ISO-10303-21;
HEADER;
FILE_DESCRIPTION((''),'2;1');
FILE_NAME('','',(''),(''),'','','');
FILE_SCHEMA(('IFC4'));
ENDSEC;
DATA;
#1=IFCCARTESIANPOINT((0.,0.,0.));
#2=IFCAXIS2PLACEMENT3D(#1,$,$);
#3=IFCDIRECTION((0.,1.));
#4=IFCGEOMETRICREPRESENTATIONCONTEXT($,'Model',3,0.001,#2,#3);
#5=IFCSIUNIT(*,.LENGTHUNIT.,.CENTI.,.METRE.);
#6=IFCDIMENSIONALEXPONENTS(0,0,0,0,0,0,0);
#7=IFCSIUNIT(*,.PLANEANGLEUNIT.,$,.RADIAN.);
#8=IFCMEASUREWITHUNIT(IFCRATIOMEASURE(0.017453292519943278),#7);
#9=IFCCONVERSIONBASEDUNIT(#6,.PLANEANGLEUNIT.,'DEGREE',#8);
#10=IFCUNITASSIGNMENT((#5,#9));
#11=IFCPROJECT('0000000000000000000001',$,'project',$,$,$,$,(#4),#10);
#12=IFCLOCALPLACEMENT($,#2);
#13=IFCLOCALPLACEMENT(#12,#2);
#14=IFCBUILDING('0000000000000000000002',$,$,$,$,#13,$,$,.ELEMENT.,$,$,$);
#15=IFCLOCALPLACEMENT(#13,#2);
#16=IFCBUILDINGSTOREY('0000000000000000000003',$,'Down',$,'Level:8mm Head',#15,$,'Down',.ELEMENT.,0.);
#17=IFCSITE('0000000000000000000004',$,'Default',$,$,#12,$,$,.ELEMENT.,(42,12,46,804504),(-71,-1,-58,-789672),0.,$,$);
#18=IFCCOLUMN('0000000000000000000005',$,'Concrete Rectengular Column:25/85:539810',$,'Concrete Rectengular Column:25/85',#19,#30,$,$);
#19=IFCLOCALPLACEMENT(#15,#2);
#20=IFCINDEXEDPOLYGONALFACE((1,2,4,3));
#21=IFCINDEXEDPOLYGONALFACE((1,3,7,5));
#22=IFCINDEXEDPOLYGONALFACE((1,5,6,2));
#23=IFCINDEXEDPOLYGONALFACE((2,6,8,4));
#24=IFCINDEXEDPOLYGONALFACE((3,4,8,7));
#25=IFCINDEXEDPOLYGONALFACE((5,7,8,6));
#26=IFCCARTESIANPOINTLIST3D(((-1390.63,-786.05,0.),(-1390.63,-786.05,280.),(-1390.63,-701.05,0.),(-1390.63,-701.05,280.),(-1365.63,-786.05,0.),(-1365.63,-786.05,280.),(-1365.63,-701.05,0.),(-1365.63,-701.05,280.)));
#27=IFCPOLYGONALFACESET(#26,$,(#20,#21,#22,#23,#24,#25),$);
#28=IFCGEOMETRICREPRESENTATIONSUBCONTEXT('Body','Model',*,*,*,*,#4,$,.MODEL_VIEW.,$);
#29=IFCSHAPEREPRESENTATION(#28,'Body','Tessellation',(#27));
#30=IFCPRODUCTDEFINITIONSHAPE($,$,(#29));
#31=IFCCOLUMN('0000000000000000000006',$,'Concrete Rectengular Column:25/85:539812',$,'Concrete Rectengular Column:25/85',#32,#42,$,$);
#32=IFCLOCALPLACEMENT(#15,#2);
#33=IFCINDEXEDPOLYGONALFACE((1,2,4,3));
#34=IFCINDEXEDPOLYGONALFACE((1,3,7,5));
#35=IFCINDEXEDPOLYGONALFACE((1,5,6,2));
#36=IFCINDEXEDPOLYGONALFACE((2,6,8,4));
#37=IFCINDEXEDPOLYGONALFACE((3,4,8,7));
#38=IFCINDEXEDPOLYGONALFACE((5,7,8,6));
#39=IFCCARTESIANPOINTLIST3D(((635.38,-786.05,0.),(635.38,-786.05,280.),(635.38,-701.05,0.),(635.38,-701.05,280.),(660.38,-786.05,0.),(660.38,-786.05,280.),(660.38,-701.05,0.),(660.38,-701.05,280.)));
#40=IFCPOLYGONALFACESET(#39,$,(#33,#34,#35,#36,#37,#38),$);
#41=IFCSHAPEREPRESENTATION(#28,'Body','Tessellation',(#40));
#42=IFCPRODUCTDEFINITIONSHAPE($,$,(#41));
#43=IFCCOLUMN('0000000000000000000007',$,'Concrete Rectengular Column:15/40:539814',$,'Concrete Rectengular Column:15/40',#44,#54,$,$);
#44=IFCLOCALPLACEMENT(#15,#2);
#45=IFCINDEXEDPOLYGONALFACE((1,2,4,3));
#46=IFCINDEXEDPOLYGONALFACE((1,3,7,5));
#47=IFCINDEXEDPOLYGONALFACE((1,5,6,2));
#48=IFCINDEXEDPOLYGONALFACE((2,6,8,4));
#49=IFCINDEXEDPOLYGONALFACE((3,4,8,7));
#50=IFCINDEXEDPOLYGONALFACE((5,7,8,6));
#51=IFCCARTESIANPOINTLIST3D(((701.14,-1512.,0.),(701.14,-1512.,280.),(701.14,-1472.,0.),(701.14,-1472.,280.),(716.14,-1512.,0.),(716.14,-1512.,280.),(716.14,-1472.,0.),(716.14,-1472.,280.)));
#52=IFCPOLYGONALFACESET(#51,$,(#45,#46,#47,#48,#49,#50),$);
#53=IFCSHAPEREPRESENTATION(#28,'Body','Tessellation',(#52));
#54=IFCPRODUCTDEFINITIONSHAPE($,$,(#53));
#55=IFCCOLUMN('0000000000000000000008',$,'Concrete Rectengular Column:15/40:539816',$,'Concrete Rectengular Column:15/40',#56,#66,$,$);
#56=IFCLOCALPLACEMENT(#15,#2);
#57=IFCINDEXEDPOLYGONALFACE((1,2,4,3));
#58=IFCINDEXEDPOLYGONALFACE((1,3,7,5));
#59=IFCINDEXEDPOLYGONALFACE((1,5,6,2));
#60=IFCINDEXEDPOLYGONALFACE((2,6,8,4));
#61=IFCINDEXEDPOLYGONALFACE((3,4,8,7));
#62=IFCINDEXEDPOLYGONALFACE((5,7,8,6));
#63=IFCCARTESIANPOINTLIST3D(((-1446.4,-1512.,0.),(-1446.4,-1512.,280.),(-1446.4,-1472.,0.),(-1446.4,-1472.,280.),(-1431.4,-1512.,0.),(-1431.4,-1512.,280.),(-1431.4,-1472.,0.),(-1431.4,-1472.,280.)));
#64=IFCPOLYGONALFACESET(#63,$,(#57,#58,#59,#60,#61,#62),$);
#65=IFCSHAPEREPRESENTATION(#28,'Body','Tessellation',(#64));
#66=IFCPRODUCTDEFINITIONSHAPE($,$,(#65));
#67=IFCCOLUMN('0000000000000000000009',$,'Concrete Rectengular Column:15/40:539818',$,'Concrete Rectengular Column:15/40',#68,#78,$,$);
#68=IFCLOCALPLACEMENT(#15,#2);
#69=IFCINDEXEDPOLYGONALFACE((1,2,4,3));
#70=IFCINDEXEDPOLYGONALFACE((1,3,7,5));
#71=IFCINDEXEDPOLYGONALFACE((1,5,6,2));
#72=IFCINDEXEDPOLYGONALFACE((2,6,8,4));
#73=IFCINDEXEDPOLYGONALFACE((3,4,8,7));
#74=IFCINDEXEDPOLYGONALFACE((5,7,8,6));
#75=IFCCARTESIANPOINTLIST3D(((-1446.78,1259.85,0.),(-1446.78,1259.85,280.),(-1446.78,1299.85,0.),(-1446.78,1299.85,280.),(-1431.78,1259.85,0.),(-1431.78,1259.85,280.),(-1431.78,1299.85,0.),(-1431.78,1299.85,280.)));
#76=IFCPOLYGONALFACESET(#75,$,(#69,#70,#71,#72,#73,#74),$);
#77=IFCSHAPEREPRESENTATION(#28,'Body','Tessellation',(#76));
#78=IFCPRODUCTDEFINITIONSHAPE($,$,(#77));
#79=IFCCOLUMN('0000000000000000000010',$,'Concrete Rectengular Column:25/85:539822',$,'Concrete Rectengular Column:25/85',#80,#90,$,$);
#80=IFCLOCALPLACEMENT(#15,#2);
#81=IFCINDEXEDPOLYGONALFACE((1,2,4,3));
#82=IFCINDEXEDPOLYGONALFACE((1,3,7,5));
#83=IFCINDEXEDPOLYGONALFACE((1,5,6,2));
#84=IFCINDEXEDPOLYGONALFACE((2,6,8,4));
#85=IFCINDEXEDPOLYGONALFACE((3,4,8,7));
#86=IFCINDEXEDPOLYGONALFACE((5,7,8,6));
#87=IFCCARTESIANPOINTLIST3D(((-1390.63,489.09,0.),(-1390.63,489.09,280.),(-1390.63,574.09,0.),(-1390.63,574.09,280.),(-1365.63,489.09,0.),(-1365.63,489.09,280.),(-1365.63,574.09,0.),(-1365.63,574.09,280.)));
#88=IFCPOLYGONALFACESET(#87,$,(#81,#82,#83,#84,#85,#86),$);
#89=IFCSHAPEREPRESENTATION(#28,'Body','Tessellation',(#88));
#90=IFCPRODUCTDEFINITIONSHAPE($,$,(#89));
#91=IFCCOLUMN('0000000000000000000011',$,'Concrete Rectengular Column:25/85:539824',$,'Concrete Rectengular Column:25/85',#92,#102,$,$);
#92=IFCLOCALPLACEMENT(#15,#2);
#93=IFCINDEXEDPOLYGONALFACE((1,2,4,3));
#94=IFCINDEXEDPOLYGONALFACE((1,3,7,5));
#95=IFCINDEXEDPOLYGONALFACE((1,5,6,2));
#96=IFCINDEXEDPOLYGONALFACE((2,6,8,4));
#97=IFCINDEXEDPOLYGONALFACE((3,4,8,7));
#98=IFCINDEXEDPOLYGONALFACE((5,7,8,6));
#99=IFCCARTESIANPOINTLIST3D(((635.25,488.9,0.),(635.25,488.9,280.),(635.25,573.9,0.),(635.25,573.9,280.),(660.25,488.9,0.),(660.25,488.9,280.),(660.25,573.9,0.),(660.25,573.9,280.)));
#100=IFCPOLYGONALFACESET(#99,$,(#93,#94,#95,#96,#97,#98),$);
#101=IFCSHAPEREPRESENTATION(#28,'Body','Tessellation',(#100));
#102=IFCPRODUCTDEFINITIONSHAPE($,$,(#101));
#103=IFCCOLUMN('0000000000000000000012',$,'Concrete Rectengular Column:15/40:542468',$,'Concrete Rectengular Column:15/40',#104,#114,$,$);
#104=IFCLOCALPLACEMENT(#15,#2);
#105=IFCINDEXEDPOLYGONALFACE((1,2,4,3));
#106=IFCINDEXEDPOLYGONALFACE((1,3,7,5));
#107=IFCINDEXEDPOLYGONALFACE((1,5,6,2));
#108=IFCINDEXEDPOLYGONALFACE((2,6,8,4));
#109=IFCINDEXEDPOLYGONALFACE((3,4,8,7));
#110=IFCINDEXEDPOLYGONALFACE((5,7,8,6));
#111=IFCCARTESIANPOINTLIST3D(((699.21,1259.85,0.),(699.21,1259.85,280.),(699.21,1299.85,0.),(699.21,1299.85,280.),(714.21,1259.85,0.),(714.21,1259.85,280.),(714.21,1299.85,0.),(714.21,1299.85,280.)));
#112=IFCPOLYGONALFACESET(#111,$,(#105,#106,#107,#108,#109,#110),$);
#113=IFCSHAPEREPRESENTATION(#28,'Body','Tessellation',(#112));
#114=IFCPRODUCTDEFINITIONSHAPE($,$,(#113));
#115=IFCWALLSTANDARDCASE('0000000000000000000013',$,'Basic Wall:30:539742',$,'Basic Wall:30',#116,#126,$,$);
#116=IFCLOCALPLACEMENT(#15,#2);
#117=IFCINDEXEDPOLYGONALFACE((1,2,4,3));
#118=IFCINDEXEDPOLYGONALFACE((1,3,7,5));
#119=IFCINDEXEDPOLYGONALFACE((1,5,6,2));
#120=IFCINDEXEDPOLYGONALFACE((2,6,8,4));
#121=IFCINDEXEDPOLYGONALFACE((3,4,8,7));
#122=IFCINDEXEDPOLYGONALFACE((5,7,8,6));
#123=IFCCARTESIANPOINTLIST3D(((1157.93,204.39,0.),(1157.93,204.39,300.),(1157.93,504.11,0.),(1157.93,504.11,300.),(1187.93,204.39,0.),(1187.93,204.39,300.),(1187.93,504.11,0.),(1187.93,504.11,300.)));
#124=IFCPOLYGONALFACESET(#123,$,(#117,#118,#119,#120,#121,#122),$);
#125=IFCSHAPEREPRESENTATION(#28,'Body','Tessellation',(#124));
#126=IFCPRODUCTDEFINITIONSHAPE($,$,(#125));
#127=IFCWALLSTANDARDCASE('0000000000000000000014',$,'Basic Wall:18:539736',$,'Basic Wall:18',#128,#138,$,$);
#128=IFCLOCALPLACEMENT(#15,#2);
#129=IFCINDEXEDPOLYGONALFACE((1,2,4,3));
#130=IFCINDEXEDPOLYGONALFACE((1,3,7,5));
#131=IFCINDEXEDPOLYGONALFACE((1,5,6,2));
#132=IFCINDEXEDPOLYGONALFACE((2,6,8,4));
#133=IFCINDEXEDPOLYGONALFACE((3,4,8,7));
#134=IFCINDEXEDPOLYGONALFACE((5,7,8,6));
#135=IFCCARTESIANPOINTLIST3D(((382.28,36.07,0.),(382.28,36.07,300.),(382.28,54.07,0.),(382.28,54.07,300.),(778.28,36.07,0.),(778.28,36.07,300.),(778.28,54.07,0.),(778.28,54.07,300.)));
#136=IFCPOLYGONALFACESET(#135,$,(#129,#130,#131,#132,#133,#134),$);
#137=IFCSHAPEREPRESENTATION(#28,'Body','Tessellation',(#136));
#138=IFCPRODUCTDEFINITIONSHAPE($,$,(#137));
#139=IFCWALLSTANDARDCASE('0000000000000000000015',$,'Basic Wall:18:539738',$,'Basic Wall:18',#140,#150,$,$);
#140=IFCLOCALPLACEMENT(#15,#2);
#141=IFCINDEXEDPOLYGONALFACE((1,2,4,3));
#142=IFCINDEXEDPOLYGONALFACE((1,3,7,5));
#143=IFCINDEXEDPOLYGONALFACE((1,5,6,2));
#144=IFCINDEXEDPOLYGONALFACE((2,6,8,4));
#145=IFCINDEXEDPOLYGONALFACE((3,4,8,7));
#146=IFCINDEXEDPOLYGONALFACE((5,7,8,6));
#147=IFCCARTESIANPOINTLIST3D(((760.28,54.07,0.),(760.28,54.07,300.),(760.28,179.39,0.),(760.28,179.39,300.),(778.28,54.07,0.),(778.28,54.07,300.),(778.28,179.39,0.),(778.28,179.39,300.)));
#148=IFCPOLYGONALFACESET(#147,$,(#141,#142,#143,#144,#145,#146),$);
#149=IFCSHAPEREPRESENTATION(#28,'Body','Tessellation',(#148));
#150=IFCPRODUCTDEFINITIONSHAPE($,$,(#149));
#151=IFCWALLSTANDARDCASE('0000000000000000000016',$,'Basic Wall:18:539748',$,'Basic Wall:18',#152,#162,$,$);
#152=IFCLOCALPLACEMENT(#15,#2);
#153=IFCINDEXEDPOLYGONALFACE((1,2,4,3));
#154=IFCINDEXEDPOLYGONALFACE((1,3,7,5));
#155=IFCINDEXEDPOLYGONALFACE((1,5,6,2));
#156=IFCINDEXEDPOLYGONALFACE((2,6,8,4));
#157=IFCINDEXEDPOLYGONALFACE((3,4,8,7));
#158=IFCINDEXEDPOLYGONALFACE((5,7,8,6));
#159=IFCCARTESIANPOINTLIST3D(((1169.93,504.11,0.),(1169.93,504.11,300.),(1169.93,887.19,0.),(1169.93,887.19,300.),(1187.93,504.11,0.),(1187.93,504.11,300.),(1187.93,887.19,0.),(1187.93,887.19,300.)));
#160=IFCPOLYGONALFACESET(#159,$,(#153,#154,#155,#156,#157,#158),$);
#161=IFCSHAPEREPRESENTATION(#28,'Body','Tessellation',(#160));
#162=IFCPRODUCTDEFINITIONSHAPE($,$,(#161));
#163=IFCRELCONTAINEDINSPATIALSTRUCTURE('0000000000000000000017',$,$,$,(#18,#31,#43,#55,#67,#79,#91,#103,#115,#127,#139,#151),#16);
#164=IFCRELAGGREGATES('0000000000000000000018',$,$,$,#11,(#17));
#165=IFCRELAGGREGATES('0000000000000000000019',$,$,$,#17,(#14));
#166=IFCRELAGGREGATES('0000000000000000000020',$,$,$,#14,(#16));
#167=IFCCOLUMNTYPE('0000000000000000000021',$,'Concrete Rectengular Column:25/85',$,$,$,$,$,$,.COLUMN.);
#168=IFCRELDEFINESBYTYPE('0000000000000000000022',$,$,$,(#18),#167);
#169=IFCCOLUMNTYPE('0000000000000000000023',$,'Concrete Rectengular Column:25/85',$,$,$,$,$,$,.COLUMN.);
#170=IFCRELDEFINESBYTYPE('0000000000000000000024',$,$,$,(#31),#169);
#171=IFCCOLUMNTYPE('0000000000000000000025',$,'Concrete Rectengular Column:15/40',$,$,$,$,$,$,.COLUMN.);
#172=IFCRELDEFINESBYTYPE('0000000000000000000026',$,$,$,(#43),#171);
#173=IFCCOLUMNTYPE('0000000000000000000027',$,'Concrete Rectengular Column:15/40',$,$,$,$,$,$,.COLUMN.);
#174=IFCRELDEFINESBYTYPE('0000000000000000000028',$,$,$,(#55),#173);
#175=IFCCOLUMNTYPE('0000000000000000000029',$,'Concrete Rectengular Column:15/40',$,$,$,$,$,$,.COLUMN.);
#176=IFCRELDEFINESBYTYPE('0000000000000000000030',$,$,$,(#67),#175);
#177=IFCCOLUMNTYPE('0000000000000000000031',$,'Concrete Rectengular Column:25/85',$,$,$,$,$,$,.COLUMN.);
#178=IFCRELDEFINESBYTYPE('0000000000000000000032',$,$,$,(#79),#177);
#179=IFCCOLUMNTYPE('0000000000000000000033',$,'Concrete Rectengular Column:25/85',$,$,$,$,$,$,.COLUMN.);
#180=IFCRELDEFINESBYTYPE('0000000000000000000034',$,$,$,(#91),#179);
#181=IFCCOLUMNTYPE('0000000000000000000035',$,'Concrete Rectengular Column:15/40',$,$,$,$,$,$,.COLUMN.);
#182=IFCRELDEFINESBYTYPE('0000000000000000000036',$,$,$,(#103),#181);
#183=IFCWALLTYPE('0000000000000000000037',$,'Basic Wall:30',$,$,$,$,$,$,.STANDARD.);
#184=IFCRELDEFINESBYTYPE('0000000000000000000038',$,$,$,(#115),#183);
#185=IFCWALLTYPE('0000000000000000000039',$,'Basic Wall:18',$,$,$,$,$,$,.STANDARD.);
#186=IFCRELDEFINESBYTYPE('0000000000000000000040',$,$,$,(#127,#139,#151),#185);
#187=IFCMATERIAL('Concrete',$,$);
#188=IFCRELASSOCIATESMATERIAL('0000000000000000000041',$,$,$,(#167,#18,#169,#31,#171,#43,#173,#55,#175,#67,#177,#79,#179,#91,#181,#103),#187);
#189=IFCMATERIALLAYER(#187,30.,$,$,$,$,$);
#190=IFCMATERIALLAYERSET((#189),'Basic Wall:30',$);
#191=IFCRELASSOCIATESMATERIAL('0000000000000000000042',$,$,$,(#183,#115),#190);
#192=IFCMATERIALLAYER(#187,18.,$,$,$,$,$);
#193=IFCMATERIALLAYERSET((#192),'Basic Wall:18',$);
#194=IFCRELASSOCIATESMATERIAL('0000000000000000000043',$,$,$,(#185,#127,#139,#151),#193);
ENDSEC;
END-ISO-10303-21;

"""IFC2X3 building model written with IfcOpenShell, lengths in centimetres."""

from ifc_helpers import new_model, entity, si_unit, converted_unit, direction, frame, frame_2d, origin, origin_2d_with_axis, place, context, subcontext, project, spatial, rectangle, extrude, source, transform, mapped, material, layer, layer_set, layer_usage, type_object, type_shapes, element, save


model = new_model("IFC2X3")

# Units and contexts
model_context = context("Model", 3, precision=0.001, world=origin(), true_north=direction((0.0, 1.0)))
body_context = subcontext(model_context, "Body", "Model", "MODEL_VIEW")
ifc_project = project(units=[si_unit("LENGTHUNIT", "METRE", prefix="CENTI"), converted_unit("PLANEANGLEUNIT", "DEGREE", entity("IfcRatioMeasure", 0.017453292519943278), si_unit("PLANEANGLEUNIT", "RADIAN"), dimensions=[0, 0, 0, 0, 0, 0, 0])], contexts=[model_context])

# Site, building, storey
site_placement = place(None, origin())
site = spatial("IfcSite", under=ifc_project, at=site_placement, Name="Default", CompositionType="ELEMENT", RefLatitude=(42, 12, 46, 804504), RefLongitude=(-71, -1, -58, -789672), RefElevation=0.0)
building_placement = place(site_placement, origin())
building = spatial("IfcBuilding", under=site, at=building_placement, CompositionType="ELEMENT")
storey_placement = place(building_placement, origin())
storey = spatial("IfcBuildingStorey", under=building, at=storey_placement, Name="Down", ObjectType="Level:8mm Head", LongName="Down", CompositionType="ELEMENT", Elevation=0.0)

# Columns
ifc_material = material(Name="Concrete")
column_type_1 = type_object("IfcColumnType", Name="Concrete Rectengular Column:25/85", PredefinedType="COLUMN", material=ifc_material)
shared_shape_1 = source(origin(), body_context, "Body", "SweptSolid", [
    extrude(rectangle(XDim=85.0, YDim=25.0, at=origin_2d_with_axis()), frame((-1378.13, -743.55, 0.0), z_axis=(0.0, 0.0, 1.0), x_axis=(0.0, -1.0, 0.0)), (0.0, 0.0, 1.0), 280.0),
])
type_shapes(column_type_1, [shared_shape_1])
column_1_placement = place(storey_placement, origin())
element("IfcColumn", 1, at=column_1_placement, inside=storey, type_object=column_type_1, material=ifc_material, Name="Concrete Rectengular Column:25/85:539810", ObjectType="Concrete Rectengular Column:25/85", context=body_context, shape_type="MappedRepresentation", body=[
    mapped(shared_shape_1, transform((0.0, 0.0, 0.0), scale=1.0)),
])
column_type_2 = type_object("IfcColumnType", Name="Concrete Rectengular Column:25/85", PredefinedType="COLUMN", material=ifc_material)
shared_shape_2 = source(origin(), body_context, "Body", "SweptSolid", [
    extrude(rectangle(XDim=85.0, YDim=25.0, at=origin_2d_with_axis()), frame((647.88, -743.55, 0.0), z_axis=(0.0, 0.0, 1.0), x_axis=(0.0, -1.0, 0.0)), (0.0, 0.0, 1.0), 280.0),
])
type_shapes(column_type_2, [shared_shape_2])
column_2_placement = place(storey_placement, origin())
element("IfcColumn", 2, at=column_2_placement, inside=storey, type_object=column_type_2, material=ifc_material, Name="Concrete Rectengular Column:25/85:539812", ObjectType="Concrete Rectengular Column:25/85", context=body_context, shape_type="MappedRepresentation", body=[
    mapped(shared_shape_2, transform((0.0, 0.0, 0.0), scale=1.0)),
])
column_type_3 = type_object("IfcColumnType", Name="Concrete Rectengular Column:15/40", PredefinedType="COLUMN", material=ifc_material)
shared_shape_3 = source(origin(), body_context, "Body", "SweptSolid", [
    extrude(rectangle(XDim=40.0, YDim=15.0, at=origin_2d_with_axis()), frame((708.64, -1492.0, 0.0), z_axis=(0.0, 0.0, 1.0), x_axis=(0.0, -1.0, 0.0)), (0.0, 0.0, 1.0), 280.0),
])
type_shapes(column_type_3, [shared_shape_3])
column_3_placement = place(storey_placement, origin())
element("IfcColumn", 3, at=column_3_placement, inside=storey, type_object=column_type_3, material=ifc_material, Name="Concrete Rectengular Column:15/40:539814", ObjectType="Concrete Rectengular Column:15/40", context=body_context, shape_type="MappedRepresentation", body=[
    mapped(shared_shape_3, transform((0.0, 0.0, 0.0), scale=1.0)),
])
column_type_4 = type_object("IfcColumnType", Name="Concrete Rectengular Column:15/40", PredefinedType="COLUMN", material=ifc_material)
shared_shape_4 = source(origin(), body_context, "Body", "SweptSolid", [
    extrude(rectangle(XDim=40.0, YDim=15.0, at=frame_2d((0.0, 0.0), x_axis=(1.0, 0.0))), frame((-1438.9, -1492.0, 0.0), z_axis=(0.0, 0.0, 1.0), x_axis=(0.0, -1.0, 0.0)), (0.0, 0.0, 1.0), 280.0),
])
type_shapes(column_type_4, [shared_shape_4])
column_4_placement = place(storey_placement, origin())
element("IfcColumn", 4, at=column_4_placement, inside=storey, type_object=column_type_4, material=ifc_material, Name="Concrete Rectengular Column:15/40:539816", ObjectType="Concrete Rectengular Column:15/40", context=body_context, shape_type="MappedRepresentation", body=[
    mapped(shared_shape_4, transform((0.0, 0.0, 0.0), scale=1.0)),
])
column_type_5 = type_object("IfcColumnType", Name="Concrete Rectengular Column:15/40", PredefinedType="COLUMN", material=ifc_material)
shared_shape_5 = source(origin(), body_context, "Body", "SweptSolid", [
    extrude(rectangle(XDim=40.0, YDim=15.0, at=origin_2d_with_axis()), frame((-1439.28, 1279.85, 0.0), z_axis=(0.0, 0.0, 1.0), x_axis=(0.0, -1.0, 0.0)), (0.0, 0.0, 1.0), 280.0),
])
type_shapes(column_type_5, [shared_shape_5])
column_5_placement = place(storey_placement, origin())
element("IfcColumn", 5, at=column_5_placement, inside=storey, type_object=column_type_5, material=ifc_material, Name="Concrete Rectengular Column:15/40:539818", ObjectType="Concrete Rectengular Column:15/40", context=body_context, shape_type="MappedRepresentation", body=[
    mapped(shared_shape_5, transform((0.0, 0.0, 0.0), scale=1.0)),
])
column_type_6 = type_object("IfcColumnType", Name="Concrete Rectengular Column:25/85", PredefinedType="COLUMN", material=ifc_material)
shared_shape_6 = source(origin(), body_context, "Body", "SweptSolid", [
    extrude(rectangle(XDim=85.0, YDim=25.0, at=origin_2d_with_axis()), frame((-1378.13, 531.59, 0.0), z_axis=(0.0, 0.0, 1.0), x_axis=(0.0, -1.0, 0.0)), (0.0, 0.0, 1.0), 280.0),
])
type_shapes(column_type_6, [shared_shape_6])
column_6_placement = place(storey_placement, origin())
element("IfcColumn", 6, at=column_6_placement, inside=storey, type_object=column_type_6, material=ifc_material, Name="Concrete Rectengular Column:25/85:539822", ObjectType="Concrete Rectengular Column:25/85", context=body_context, shape_type="MappedRepresentation", body=[
    mapped(shared_shape_6, transform((0.0, 0.0, 0.0), scale=1.0)),
])
column_type_7 = type_object("IfcColumnType", Name="Concrete Rectengular Column:25/85", PredefinedType="COLUMN", material=ifc_material)
shared_shape_7 = source(origin(), body_context, "Body", "SweptSolid", [
    extrude(rectangle(XDim=85.0, YDim=25.0, at=origin_2d_with_axis()), frame((647.75, 531.4, 0.0), z_axis=(0.0, 0.0, 1.0), x_axis=(0.0, -1.0, 0.0)), (0.0, 0.0, 1.0), 280.0),
])
type_shapes(column_type_7, [shared_shape_7])
column_7_placement = place(storey_placement, origin())
element("IfcColumn", 7, at=column_7_placement, inside=storey, type_object=column_type_7, material=ifc_material, Name="Concrete Rectengular Column:25/85:539824", ObjectType="Concrete Rectengular Column:25/85", context=body_context, shape_type="MappedRepresentation", body=[
    mapped(shared_shape_7, transform((0.0, 0.0, 0.0), scale=1.0)),
])
column_type_8 = type_object("IfcColumnType", Name="Concrete Rectengular Column:15/40", PredefinedType="COLUMN", material=ifc_material)
shared_shape_8 = source(origin(), body_context, "Body", "SweptSolid", [
    extrude(rectangle(XDim=40.0, YDim=15.0, at=origin_2d_with_axis()), frame((706.71, 1279.85, 0.0), z_axis=(0.0, 0.0, 1.0), x_axis=(0.0, -1.0, 0.0)), (0.0, 0.0, 1.0), 280.0),
])
type_shapes(column_type_8, [shared_shape_8])
column_8_placement = place(storey_placement, origin())
element("IfcColumn", 8, at=column_8_placement, inside=storey, type_object=column_type_8, material=ifc_material, Name="Concrete Rectengular Column:15/40:542468", ObjectType="Concrete Rectengular Column:15/40", context=body_context, shape_type="MappedRepresentation", body=[
    mapped(shared_shape_8, transform((0.0, 0.0, 0.0), scale=1.0)),
])

# Walls
ifc_layer_1 = layer(ifc_material, 30.0)
ifc_layer_set_1 = layer_set([ifc_layer_1], Name="Basic Wall:30")
ifc_layer_usage_1 = layer_usage(ifc_layer_set_1, "AXIS2", "POSITIVE", -15.0)
wall_type_1 = type_object("IfcWallType", Name="Basic Wall:30", PredefinedType="STANDARD", material=ifc_layer_set_1)
wall_1_placement = place(storey_placement, frame((1172.93, 204.39, 0.0), z_axis=(0.0, 0.0, 1.0), x_axis=(0.0, 1.0, 0.0)))
element("IfcWallStandardCase", 9, at=wall_1_placement, inside=storey, type_object=wall_type_1, material=ifc_layer_usage_1, Name="Basic Wall:30:539742", ObjectType="Basic Wall:30", context=body_context, shape_type="SweptSolid", body=[
    extrude(rectangle(XDim=299.72, YDim=30.0, at=frame_2d((149.86, 0.0), x_axis=(-1.0, 0.0))), origin(), (0.0, 0.0, 1.0), 300.0),
])
ifc_layer_2 = layer(ifc_material, 18.0)
ifc_layer_set_2 = layer_set([ifc_layer_2], Name="Basic Wall:18")
ifc_layer_usage_2 = layer_usage(ifc_layer_set_2, "AXIS2", "POSITIVE", -9.0)
wall_type_2 = type_object("IfcWallType", Name="Basic Wall:18", PredefinedType="STANDARD", material=ifc_layer_set_2)
wall_2_placement = place(storey_placement, frame((382.28, 45.07, 0.0)))
element("IfcWallStandardCase", 10, at=wall_2_placement, inside=storey, type_object=wall_type_2, material=ifc_layer_usage_2, Name="Basic Wall:18:539736", ObjectType="Basic Wall:18", context=body_context, shape_type="SweptSolid", body=[
    extrude(rectangle(XDim=396.0, YDim=18.0, at=frame_2d((198.0, 0.0), x_axis=(-1.0, 0.0))), origin(), (0.0, 0.0, 1.0), 300.0),
])
ifc_layer_usage_3 = layer_usage(ifc_layer_set_2, "AXIS2", "NEGATIVE", 9.0)
wall_3_placement = place(storey_placement, frame((769.28, 54.07, 0.0), z_axis=(0.0, 0.0, 1.0), x_axis=(0.0, 1.0, 0.0)))
element("IfcWallStandardCase", 11, at=wall_3_placement, inside=storey, type_object=wall_type_2, material=ifc_layer_usage_3, Name="Basic Wall:18:539738", ObjectType="Basic Wall:18", context=body_context, shape_type="SweptSolid", body=[
    extrude(rectangle(XDim=125.32, YDim=18.0, at=frame_2d((62.66, 0.0), x_axis=(-1.0, 0.0))), origin(), (0.0, 0.0, 1.0), 300.0),
])
ifc_layer_usage_4 = layer_usage(ifc_layer_set_2, "AXIS2", "POSITIVE", -9.0)
wall_4_placement = place(storey_placement, frame((1178.93, 887.19, 0.0), z_axis=(0.0, 0.0, 1.0), x_axis=(0.0, -1.0, 0.0)))
element("IfcWallStandardCase", 12, at=wall_4_placement, inside=storey, type_object=wall_type_2, material=ifc_layer_usage_4, Name="Basic Wall:18:539748", ObjectType="Basic Wall:18", context=body_context, shape_type="SweptSolid", body=[
    extrude(rectangle(XDim=383.08, YDim=18.0, at=frame_2d((191.54, 0.0), x_axis=(-1.0, 0.0))), origin(), (0.0, 0.0, 1.0), 300.0),
])

save(model, "model.ifc")
